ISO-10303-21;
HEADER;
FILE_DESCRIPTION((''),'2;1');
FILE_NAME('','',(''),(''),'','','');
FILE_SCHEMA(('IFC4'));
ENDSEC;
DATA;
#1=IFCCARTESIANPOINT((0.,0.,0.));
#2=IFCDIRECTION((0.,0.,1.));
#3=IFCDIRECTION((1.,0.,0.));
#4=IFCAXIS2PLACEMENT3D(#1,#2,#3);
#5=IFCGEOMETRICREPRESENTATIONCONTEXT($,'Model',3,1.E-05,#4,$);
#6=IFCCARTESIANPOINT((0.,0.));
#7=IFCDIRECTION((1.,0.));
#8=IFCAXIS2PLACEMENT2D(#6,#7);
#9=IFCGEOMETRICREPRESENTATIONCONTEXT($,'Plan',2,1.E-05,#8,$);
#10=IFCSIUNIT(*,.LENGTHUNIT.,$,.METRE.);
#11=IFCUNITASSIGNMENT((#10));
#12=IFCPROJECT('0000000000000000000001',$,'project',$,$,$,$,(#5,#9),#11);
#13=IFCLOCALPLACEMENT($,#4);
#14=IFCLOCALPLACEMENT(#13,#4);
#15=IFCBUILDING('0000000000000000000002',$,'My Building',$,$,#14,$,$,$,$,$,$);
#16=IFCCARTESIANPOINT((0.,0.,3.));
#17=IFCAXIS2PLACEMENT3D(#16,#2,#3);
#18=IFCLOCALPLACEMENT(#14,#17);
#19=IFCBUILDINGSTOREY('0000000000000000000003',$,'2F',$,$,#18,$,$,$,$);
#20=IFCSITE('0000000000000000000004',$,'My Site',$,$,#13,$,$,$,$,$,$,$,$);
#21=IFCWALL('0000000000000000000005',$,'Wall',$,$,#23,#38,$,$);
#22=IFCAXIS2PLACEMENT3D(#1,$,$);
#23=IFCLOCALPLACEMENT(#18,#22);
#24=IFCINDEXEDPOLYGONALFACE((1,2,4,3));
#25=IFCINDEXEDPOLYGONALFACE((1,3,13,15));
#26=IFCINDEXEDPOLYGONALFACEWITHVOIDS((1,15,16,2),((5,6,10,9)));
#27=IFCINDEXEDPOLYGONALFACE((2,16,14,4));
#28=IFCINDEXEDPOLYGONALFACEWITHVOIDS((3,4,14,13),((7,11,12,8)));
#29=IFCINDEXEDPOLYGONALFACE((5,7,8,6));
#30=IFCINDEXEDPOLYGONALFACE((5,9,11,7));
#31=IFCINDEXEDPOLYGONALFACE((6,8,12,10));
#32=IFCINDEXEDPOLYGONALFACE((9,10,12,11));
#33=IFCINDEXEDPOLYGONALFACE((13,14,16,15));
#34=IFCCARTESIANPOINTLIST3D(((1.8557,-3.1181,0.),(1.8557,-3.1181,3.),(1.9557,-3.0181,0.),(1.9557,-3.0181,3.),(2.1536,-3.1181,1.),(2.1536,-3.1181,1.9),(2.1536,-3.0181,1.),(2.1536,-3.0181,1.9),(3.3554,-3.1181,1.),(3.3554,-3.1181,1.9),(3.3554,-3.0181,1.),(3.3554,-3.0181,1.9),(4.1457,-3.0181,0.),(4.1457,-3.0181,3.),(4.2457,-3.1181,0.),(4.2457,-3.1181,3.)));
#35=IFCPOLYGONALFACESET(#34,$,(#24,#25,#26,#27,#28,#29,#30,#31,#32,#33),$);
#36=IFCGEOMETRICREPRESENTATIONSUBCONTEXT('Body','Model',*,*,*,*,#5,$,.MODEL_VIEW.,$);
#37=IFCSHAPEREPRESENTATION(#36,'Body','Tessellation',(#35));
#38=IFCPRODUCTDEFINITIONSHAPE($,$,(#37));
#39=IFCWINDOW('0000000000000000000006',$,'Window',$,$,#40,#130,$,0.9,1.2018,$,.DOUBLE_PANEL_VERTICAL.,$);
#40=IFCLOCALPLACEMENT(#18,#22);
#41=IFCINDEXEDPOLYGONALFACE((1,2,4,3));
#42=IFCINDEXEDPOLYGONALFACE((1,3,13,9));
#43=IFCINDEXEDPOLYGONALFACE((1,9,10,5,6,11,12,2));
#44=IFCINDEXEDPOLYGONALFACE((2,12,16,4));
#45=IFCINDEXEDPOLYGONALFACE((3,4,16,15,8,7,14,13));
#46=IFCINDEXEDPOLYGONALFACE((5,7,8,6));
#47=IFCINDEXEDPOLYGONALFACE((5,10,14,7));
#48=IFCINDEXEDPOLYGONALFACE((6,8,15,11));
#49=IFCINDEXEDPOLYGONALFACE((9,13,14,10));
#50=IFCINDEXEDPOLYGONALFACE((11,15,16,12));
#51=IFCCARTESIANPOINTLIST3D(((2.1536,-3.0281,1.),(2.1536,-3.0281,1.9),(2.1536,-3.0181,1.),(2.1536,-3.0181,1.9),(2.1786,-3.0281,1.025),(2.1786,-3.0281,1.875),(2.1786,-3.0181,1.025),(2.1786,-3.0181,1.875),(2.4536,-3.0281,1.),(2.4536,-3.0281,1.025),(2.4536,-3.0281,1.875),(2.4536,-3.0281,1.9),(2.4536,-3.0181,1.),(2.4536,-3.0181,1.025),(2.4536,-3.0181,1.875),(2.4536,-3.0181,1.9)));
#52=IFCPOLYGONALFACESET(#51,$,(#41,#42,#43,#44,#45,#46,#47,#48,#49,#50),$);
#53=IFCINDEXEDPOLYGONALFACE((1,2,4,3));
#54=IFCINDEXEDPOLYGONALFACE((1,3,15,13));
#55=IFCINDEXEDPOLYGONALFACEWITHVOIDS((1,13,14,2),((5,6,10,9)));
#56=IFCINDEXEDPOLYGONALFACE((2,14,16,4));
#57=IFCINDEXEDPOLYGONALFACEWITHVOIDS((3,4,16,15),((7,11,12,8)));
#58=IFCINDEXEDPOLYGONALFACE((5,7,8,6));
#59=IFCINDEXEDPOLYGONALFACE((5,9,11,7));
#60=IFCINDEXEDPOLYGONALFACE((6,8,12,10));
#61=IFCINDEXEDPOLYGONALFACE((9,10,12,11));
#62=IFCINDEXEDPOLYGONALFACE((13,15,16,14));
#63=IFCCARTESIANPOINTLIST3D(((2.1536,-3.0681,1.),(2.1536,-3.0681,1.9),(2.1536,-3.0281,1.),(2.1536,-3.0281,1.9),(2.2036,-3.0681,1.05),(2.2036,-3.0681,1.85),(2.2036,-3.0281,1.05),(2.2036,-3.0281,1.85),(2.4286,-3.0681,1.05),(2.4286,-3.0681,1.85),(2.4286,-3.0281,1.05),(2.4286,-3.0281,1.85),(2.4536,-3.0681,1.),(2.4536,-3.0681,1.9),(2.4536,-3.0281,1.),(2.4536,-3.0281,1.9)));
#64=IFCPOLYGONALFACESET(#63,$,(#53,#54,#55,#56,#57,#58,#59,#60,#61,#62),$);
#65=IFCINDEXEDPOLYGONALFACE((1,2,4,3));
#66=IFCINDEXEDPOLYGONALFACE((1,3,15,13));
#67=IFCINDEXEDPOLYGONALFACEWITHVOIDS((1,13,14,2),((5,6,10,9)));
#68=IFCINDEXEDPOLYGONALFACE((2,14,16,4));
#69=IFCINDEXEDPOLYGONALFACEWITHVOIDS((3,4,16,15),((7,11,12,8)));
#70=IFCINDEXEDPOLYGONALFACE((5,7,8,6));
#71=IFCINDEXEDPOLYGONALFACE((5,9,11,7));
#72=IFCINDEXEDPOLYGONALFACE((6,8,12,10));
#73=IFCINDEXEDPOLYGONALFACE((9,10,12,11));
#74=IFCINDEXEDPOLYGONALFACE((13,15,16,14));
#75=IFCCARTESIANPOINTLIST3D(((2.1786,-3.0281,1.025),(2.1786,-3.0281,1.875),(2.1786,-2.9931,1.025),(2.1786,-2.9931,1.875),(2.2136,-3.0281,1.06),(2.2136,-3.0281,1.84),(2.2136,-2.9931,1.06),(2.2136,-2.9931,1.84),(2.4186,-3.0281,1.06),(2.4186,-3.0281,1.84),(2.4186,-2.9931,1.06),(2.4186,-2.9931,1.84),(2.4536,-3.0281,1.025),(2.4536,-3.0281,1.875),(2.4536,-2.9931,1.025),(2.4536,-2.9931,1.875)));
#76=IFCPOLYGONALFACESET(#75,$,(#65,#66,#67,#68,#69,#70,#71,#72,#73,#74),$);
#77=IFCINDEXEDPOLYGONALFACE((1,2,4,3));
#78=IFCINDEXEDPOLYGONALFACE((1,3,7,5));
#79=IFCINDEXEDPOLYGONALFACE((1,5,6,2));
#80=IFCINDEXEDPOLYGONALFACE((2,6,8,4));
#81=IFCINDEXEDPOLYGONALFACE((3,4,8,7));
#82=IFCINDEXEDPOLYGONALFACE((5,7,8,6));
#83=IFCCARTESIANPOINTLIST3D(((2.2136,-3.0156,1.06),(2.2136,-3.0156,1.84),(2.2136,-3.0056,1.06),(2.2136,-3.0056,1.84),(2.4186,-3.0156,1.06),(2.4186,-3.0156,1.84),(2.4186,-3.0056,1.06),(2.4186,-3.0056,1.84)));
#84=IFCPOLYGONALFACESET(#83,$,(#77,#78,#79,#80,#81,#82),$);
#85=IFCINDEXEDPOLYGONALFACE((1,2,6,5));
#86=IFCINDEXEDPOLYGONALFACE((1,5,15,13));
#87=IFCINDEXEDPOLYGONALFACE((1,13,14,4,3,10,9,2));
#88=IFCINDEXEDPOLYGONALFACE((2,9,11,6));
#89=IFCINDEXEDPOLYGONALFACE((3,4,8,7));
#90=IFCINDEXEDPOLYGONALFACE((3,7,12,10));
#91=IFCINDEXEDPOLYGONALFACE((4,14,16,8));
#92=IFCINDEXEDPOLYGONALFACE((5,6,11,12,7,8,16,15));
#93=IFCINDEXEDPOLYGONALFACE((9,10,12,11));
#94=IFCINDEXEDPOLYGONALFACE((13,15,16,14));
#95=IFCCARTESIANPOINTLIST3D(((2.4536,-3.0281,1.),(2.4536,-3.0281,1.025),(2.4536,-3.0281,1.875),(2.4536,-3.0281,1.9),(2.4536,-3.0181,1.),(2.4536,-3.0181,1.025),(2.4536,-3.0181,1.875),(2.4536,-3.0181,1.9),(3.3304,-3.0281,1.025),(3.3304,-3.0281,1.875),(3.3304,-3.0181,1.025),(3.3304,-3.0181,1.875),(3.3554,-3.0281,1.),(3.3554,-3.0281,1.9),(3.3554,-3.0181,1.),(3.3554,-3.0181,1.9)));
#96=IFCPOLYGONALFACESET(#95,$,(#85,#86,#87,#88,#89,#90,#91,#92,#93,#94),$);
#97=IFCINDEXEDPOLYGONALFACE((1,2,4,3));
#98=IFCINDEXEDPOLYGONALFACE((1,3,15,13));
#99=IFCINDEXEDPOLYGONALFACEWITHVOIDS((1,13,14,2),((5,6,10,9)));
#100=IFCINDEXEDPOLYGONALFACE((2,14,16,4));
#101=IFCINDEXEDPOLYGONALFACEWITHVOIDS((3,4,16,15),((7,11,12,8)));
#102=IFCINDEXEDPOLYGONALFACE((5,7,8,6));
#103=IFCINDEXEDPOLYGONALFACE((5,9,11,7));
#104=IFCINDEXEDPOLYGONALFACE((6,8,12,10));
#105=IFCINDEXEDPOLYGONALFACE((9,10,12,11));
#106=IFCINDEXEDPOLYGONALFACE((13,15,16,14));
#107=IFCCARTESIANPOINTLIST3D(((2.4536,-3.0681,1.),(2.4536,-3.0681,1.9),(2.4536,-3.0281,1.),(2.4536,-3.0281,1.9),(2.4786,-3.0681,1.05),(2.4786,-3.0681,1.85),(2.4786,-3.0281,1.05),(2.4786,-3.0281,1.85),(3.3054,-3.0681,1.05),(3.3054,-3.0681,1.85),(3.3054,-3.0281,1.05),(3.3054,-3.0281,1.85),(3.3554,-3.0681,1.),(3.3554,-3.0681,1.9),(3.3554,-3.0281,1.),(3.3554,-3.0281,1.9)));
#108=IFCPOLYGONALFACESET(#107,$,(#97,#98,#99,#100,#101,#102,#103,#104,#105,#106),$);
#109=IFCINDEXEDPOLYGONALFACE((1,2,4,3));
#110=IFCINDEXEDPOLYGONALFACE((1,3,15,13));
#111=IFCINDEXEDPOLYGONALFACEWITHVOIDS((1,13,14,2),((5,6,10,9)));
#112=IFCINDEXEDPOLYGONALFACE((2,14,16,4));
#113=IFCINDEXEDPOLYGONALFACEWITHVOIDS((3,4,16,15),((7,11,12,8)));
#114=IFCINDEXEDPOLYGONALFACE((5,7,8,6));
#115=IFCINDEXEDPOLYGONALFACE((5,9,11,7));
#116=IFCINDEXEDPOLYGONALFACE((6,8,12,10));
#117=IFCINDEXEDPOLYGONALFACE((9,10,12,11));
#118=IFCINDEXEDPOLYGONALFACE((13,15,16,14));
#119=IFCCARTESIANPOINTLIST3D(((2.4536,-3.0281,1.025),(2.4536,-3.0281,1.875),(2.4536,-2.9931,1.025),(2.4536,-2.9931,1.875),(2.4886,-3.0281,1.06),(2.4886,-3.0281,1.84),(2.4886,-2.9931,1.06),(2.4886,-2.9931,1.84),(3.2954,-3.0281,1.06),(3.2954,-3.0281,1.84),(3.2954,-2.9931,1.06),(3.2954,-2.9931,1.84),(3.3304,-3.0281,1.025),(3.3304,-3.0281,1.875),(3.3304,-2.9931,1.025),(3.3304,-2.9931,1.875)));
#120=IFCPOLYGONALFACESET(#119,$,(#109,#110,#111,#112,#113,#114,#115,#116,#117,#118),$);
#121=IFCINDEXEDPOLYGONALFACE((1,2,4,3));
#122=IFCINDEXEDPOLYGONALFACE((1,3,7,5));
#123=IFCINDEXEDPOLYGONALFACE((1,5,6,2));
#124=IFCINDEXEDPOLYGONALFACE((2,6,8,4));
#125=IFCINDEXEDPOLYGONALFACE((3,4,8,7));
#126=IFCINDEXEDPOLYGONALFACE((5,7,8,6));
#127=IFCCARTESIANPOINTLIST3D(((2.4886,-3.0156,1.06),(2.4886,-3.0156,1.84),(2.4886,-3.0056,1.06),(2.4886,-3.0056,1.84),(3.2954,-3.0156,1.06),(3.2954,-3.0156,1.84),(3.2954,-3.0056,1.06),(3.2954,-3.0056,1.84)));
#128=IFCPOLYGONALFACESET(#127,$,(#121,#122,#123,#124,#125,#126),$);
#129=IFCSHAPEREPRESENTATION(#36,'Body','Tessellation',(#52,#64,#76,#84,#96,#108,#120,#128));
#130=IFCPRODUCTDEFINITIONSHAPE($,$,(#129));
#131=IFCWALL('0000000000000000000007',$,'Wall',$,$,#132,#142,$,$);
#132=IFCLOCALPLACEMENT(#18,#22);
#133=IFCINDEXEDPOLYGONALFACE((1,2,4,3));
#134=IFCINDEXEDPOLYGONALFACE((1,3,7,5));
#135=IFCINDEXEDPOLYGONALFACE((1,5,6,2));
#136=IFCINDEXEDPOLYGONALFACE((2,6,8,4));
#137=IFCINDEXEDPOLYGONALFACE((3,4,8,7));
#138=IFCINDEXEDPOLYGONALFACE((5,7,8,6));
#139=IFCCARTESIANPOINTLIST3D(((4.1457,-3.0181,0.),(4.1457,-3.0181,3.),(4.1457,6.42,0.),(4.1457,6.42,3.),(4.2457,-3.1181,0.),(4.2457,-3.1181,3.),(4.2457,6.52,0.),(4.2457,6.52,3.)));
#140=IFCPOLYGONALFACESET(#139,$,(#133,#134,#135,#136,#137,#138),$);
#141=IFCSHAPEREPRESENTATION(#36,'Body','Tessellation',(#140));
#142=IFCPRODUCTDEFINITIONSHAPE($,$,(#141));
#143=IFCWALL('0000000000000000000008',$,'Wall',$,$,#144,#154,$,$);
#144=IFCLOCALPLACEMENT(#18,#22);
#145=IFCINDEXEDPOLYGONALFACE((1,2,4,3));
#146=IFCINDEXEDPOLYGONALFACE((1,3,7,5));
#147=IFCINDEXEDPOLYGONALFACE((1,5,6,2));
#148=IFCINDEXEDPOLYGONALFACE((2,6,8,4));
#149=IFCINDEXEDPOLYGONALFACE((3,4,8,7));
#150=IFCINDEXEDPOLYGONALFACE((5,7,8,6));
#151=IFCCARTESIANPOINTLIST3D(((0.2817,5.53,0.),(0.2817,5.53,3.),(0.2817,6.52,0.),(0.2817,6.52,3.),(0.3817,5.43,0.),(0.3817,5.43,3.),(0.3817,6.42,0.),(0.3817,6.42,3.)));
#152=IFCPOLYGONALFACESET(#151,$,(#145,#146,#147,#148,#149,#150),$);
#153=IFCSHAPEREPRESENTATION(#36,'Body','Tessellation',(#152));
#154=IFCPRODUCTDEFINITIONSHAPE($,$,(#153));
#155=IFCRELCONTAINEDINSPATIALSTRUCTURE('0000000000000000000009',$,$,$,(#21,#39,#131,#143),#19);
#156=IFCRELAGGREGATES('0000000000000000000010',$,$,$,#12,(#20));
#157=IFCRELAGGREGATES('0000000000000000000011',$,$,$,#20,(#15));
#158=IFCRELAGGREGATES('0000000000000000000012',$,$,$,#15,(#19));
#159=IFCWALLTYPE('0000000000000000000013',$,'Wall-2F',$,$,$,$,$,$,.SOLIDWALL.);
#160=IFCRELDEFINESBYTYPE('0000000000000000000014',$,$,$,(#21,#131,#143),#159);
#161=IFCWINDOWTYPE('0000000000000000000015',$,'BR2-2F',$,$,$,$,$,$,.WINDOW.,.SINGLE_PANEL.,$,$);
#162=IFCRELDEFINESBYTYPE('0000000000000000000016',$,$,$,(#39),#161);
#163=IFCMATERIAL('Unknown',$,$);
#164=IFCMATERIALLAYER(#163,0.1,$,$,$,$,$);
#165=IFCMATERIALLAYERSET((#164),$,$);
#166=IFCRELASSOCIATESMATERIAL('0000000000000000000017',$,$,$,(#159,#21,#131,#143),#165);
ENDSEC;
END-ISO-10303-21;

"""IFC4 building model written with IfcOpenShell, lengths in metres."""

from ifc_helpers import new_model, entity, si_unit, frame, origin_with_axes, origin_2d_with_axis, place, context, subcontext, project, spatial, line, indexed_curve, outline, extrude, shape, source, transform, mapped, material, layer, layer_set, layer_usage, type_object, type_shapes, element, fill, save


model = new_model("IFC4")

# Units and contexts
model_context = context("Model", 3, precision=1e-05, world=origin_with_axes())
plan_context = context("Plan", 2, precision=1e-05, world=origin_2d_with_axis())
body_context_1 = subcontext(model_context, "Body", "Model", "MODEL_VIEW")
body_context_2 = subcontext(plan_context, "Body", "Plan", "PLAN_VIEW")
ifc_project = project(units=[si_unit("LENGTHUNIT", "METRE")], contexts=[model_context, plan_context])

# Site, building, storey
site_placement = place(None, origin_with_axes())
site = spatial("IfcSite", under=ifc_project, at=site_placement, Name="My Site")
building_placement = place(site_placement, origin_with_axes())
building = spatial("IfcBuilding", under=site, at=building_placement, Name="My Building")
storey_placement = place(building_placement, frame((0.0, 0.0, 3.0), z_axis=(0.0, 0.0, 1.0), x_axis=(1.0, 0.0, 0.0)))
storey = spatial("IfcBuildingStorey", under=building, at=storey_placement, Name="2F")

# Shared definitions
ifc_material = material(Name="Unknown")

# Shared definitions
ifc_layer_1 = layer(ifc_material, 0.1)
ifc_layer_set_1 = layer_set([ifc_layer_1])
wall_type_1 = type_object("IfcWallType", Name="Wall-2F", PredefinedType="SOLIDWALL", material=ifc_layer_set_1)

# Wall, opening, window
ifc_layer_usage_1 = layer_usage(ifc_layer_set_1, "AXIS2", "POSITIVE", 0.0)
wall_1_placement = place(storey_placement, frame((1.8557, -3.1181, 0.0), z_axis=(0.0, 0.0, 1.0), x_axis=(1.0, 0.0, 0.0)))
wall_1 = element("IfcWall", 1, at=wall_1_placement, inside=storey, type_object=wall_type_1, material=ifc_layer_usage_1, Name="Wall", context=body_context_1, shape_type="SweptSolid", body=[
    extrude(outline(indexed_curve([(0.0, 0.0), (0.1, 0.1), (2.29, 0.1), (2.39, 0.0)], segments=[line(1, 2, 3, 4, 1)])), origin_with_axes(), (0.0, 0.0, 1.0), 3.0),
])
shared_shape_1 = source(origin_with_axes(), body_context_1, "Body", "SweptSolid", [
    extrude(outline(indexed_curve([(0.0, 0.0), (1.2018, 0.0), (1.2018, 0.9), (0.0, 0.9)], segments=[line(1, 2, 3, 4, 1)])), frame((0.0, -0.6, 0.0), z_axis=(0.0, -1.0, 0.0), x_axis=(1.0, 0.0, 0.0)), (0.0, 0.0, -1.0), 1.2),
])
opening_1_placement = place(wall_1_placement, frame((0.2979, 0.0, 1.0), z_axis=(0.0, 0.0, 1.0), x_axis=(1.0, 0.0, 0.0)))
opening_1 = element("IfcOpeningElement", 2, at=opening_1_placement, cuts=wall_1, PredefinedType="OPENING", context=body_context_1, shape_type="MappedRepresentation", body=[
    mapped(shared_shape_1, transform((0.0, 0.0, 0.0), x_axis=(1.0, 0.0, 0.0), y_axis=(0.0, 1.0, 0.0), z_axis=(0.0, 0.0, 1.0), scale=1.0)),
])
window_type_1 = type_object("IfcWindowType", Name="BR2-2F", PartitioningType="SINGLE_PANEL", PredefinedType="WINDOW")
shared_shape_2 = source(origin_with_axes(), body_context_1, "Body", "SweptSolid", [
    extrude(outline(indexed_curve([(0.3, 0.0), (0.0, 0.0), (0.0, 0.9), (0.3, 0.9), (0.3, 0.875), (0.025, 0.875), (0.025, 0.025), (0.3, 0.025)], segments=[line(1, 2, 3, 4, 5, 6, 7, 8, 1)])), frame((0.0, 0.09, 0.0), z_axis=(0.0, -1.0, 0.0), x_axis=(1.0, 0.0, 0.0)), (0.0, 0.0, -1.0), 0.01),
    extrude(outline(indexed_curve([(0.0, 0.0), (0.3, 0.0), (0.3, 0.9), (0.0, 0.9)], segments=[line(1, 2, 3, 4, 1)]), holes=[indexed_curve([(0.05, 0.05), (0.275, 0.05), (0.275, 0.85), (0.05, 0.85)], segments=[line(1, 2, 3, 4, 1)])]), frame((0.0, 0.05, 0.0), z_axis=(0.0, -1.0, 0.0), x_axis=(1.0, 0.0, 0.0)), (0.0, 0.0, -1.0), 0.04),
    extrude(outline(indexed_curve([(0.0, 0.0), (0.275, 0.0), (0.275, 0.85), (0.0, 0.85)], segments=[line(1, 2, 3, 4, 1)]), holes=[indexed_curve([(0.035, 0.035), (0.24, 0.035), (0.24, 0.815), (0.035, 0.815)], segments=[line(1, 2, 3, 4, 1)])]), frame((0.025, 0.09, 0.025), z_axis=(0.0, -1.0, 0.0), x_axis=(1.0, 0.0, 0.0)), (0.0, 0.0, -1.0), 0.035),
    extrude(outline(indexed_curve([(0.035, 0.035), (0.24, 0.035), (0.24, 0.815), (0.035, 0.815)], segments=[line(1, 2, 3, 4, 1)])), frame((0.025, 0.1025, 0.025), z_axis=(0.0, -1.0, 0.0), x_axis=(1.0, 0.0, 0.0)), (0.0, 0.0, -1.0), 0.01),
    extrude(outline(indexed_curve([(0.0, 0.9), (0.9018, 0.9), (0.9018, 0.0), (0.0, 0.0), (0.0, 0.025), (0.8768, 0.025), (0.8768, 0.875), (0.0, 0.875)], segments=[line(1, 2, 3, 4, 5, 6, 7, 8, 1)])), frame((0.3, 0.09, 0.0), z_axis=(0.0, -1.0, 0.0), x_axis=(1.0, 0.0, 0.0)), (0.0, 0.0, -1.0), 0.01),
    extrude(outline(indexed_curve([(0.0, 0.0), (0.9018, 0.0), (0.9018, 0.9), (0.0, 0.9)], segments=[line(1, 2, 3, 4, 1)]), holes=[indexed_curve([(0.025, 0.05), (0.8518, 0.05), (0.8518, 0.85), (0.025, 0.85)], segments=[line(1, 2, 3, 4, 1)])]), frame((0.3, 0.05, 0.0), z_axis=(0.0, -1.0, 0.0), x_axis=(1.0, 0.0, 0.0)), (0.0, 0.0, -1.0), 0.04),
    extrude(outline(indexed_curve([(0.0, 0.0), (0.8768, 0.0), (0.8768, 0.85), (0.0, 0.85)], segments=[line(1, 2, 3, 4, 1)]), holes=[indexed_curve([(0.035, 0.035), (0.8418, 0.035), (0.8418, 0.815), (0.035, 0.815)], segments=[line(1, 2, 3, 4, 1)])]), frame((0.3, 0.09, 0.025), z_axis=(0.0, -1.0, 0.0), x_axis=(1.0, 0.0, 0.0)), (0.0, 0.0, -1.0), 0.035),
    extrude(outline(indexed_curve([(0.035, 0.035), (0.8418, 0.035), (0.8418, 0.815), (0.035, 0.815)], segments=[line(1, 2, 3, 4, 1)])), frame((0.3, 0.1025, 0.025), z_axis=(0.0, -1.0, 0.0), x_axis=(1.0, 0.0, 0.0)), (0.0, 0.0, -1.0), 0.01),
])
shared_shape_3 = source(origin_with_axes(), body_context_2, "Body", "Curve2D", [
    entity("IfcIndexedPolyCurve", entity("IfcCartesianPointList2D", [[0.05, 0.05], [0.275, 0.05]])),
    entity("IfcIndexedPolyCurve", entity("IfcCartesianPointList2D", [[0.0, 0.1], [0.025, 0.1], [0.025, 0.09], [0.05, 0.09], [0.05, 0.05], [0.0, 0.05]]), [entity("IfcLineIndex", [1, 2, 3, 4, 5, 6, 1])]),
    entity("IfcIndexedPolyCurve", entity("IfcCartesianPointList2D", [[0.3, 0.1], [0.3, 0.1], [0.3, 0.09], [0.275, 0.09], [0.275, 0.05], [0.3, 0.05]])),
    entity("IfcIndexedPolyCurve", entity("IfcCartesianPointList2D", [[0.025, 0.09], [0.06, 0.09], [0.06, 0.125], [0.025, 0.125]]), [entity("IfcLineIndex", [1, 2, 3, 4, 1])]),
    entity("IfcIndexedPolyCurve", entity("IfcCartesianPointList2D", [[0.3, 0.09], [0.265, 0.09], [0.265, 0.125], [0.3, 0.125]]), [entity("IfcLineIndex", [1, 2, 3, 4, 1])]),
    entity("IfcIndexedPolyCurve", entity("IfcCartesianPointList2D", [[0.06, 0.09], [0.265, 0.09]])),
    entity("IfcIndexedPolyCurve", entity("IfcCartesianPointList2D", [[0.06, 0.125], [0.265, 0.125]])),
    entity("IfcIndexedPolyCurve", entity("IfcCartesianPointList2D", [[0.06, 0.1075], [0.265, 0.1075]])),
    entity("IfcIndexedPolyCurve", entity("IfcCartesianPointList2D", [[0.325, 0.05], [1.1518, 0.05]])),
    entity("IfcIndexedPolyCurve", entity("IfcCartesianPointList2D", [[0.3, 0.1], [0.3, 0.1], [0.3, 0.09], [0.325, 0.09], [0.325, 0.05], [0.3, 0.05]])),
    entity("IfcIndexedPolyCurve", entity("IfcCartesianPointList2D", [[1.2018, 0.1], [1.1768, 0.1], [1.1768, 0.09], [1.1518, 0.09], [1.1518, 0.05], [1.2018, 0.05]]), [entity("IfcLineIndex", [1, 2, 3, 4, 5, 6, 1])]),
    entity("IfcIndexedPolyCurve", entity("IfcCartesianPointList2D", [[0.3, 0.09], [0.335, 0.09], [0.335, 0.125], [0.3, 0.125]]), [entity("IfcLineIndex", [1, 2, 3, 4, 1])]),
    entity("IfcIndexedPolyCurve", entity("IfcCartesianPointList2D", [[1.1768, 0.09], [1.1418, 0.09], [1.1418, 0.125], [1.1768, 0.125]]), [entity("IfcLineIndex", [1, 2, 3, 4, 1])]),
    entity("IfcIndexedPolyCurve", entity("IfcCartesianPointList2D", [[0.335, 0.09], [1.1418, 0.09]])),
    entity("IfcIndexedPolyCurve", entity("IfcCartesianPointList2D", [[0.335, 0.125], [1.1418, 0.125]])),
    entity("IfcIndexedPolyCurve", entity("IfcCartesianPointList2D", [[0.335, 0.1075], [1.1418, 0.1075]])),
])
type_shapes(window_type_1, [shared_shape_2, shared_shape_3])
window_1_placement = place(opening_1_placement, origin_with_axes())
window_1 = element("IfcWindow", 3, at=window_1_placement, inside=storey, type_object=window_type_1, Name="Window", OverallHeight=0.9, OverallWidth=1.2018, PartitioningType="DOUBLE_PANEL_VERTICAL", shapes=[
    shape(body_context_1, "Body", "MappedRepresentation", [mapped(shared_shape_2, transform((0.0, 0.0, 0.0), x_axis=(1.0, 0.0, 0.0), y_axis=(0.0, 1.0, 0.0), z_axis=(0.0, 0.0, 1.0), scale=1.0))]),
    shape(body_context_2, "Body", "MappedRepresentation", [mapped(shared_shape_3, transform((0.0, 0.0, 0.0), x_axis=(1.0, 0.0, 0.0), y_axis=(0.0, 1.0, 0.0), z_axis=(0.0, 0.0, 1.0), scale=1.0))]),
])
fill(opening_1, window_1)

# Walls
ifc_layer_usage_2 = layer_usage(ifc_layer_set_1, "AXIS2", "POSITIVE", 0.0)
wall_2_placement = place(storey_placement, frame((4.2457, -3.1181, 0.0), z_axis=(0.0, 0.0, 1.0), x_axis=(0.0, 1.0, 0.0)))
element("IfcWall", 4, at=wall_2_placement, inside=storey, type_object=wall_type_1, material=ifc_layer_usage_2, Name="Wall", context=body_context_1, shape_type="SweptSolid", body=[
    extrude(outline(indexed_curve([(0.0, 0.0), (0.1, 0.1), (9.5381, 0.1), (9.6381, 0.0)], segments=[line(1, 2, 3, 4, 1)])), origin_with_axes(), (0.0, 0.0, 1.0), 3.0),
])
ifc_layer_usage_3 = layer_usage(ifc_layer_set_1, "AXIS2", "POSITIVE", 0.0)
wall_3_placement = place(storey_placement, frame((0.2817, 6.52, 0.0), z_axis=(0.0, 0.0, 1.0), x_axis=(0.0, -1.0, 0.0)))
element("IfcWall", 5, at=wall_3_placement, inside=storey, type_object=wall_type_1, material=ifc_layer_usage_3, Name="Wall", context=body_context_1, shape_type="SweptSolid", body=[
    extrude(outline(indexed_curve([(0.0, 0.0), (0.1, 0.1), (1.09, 0.1), (0.99, 0.0)], segments=[line(1, 2, 3, 4, 1)])), origin_with_axes(), (0.0, 0.0, 1.0), 3.0),
])

save(model, "model.ifc")
